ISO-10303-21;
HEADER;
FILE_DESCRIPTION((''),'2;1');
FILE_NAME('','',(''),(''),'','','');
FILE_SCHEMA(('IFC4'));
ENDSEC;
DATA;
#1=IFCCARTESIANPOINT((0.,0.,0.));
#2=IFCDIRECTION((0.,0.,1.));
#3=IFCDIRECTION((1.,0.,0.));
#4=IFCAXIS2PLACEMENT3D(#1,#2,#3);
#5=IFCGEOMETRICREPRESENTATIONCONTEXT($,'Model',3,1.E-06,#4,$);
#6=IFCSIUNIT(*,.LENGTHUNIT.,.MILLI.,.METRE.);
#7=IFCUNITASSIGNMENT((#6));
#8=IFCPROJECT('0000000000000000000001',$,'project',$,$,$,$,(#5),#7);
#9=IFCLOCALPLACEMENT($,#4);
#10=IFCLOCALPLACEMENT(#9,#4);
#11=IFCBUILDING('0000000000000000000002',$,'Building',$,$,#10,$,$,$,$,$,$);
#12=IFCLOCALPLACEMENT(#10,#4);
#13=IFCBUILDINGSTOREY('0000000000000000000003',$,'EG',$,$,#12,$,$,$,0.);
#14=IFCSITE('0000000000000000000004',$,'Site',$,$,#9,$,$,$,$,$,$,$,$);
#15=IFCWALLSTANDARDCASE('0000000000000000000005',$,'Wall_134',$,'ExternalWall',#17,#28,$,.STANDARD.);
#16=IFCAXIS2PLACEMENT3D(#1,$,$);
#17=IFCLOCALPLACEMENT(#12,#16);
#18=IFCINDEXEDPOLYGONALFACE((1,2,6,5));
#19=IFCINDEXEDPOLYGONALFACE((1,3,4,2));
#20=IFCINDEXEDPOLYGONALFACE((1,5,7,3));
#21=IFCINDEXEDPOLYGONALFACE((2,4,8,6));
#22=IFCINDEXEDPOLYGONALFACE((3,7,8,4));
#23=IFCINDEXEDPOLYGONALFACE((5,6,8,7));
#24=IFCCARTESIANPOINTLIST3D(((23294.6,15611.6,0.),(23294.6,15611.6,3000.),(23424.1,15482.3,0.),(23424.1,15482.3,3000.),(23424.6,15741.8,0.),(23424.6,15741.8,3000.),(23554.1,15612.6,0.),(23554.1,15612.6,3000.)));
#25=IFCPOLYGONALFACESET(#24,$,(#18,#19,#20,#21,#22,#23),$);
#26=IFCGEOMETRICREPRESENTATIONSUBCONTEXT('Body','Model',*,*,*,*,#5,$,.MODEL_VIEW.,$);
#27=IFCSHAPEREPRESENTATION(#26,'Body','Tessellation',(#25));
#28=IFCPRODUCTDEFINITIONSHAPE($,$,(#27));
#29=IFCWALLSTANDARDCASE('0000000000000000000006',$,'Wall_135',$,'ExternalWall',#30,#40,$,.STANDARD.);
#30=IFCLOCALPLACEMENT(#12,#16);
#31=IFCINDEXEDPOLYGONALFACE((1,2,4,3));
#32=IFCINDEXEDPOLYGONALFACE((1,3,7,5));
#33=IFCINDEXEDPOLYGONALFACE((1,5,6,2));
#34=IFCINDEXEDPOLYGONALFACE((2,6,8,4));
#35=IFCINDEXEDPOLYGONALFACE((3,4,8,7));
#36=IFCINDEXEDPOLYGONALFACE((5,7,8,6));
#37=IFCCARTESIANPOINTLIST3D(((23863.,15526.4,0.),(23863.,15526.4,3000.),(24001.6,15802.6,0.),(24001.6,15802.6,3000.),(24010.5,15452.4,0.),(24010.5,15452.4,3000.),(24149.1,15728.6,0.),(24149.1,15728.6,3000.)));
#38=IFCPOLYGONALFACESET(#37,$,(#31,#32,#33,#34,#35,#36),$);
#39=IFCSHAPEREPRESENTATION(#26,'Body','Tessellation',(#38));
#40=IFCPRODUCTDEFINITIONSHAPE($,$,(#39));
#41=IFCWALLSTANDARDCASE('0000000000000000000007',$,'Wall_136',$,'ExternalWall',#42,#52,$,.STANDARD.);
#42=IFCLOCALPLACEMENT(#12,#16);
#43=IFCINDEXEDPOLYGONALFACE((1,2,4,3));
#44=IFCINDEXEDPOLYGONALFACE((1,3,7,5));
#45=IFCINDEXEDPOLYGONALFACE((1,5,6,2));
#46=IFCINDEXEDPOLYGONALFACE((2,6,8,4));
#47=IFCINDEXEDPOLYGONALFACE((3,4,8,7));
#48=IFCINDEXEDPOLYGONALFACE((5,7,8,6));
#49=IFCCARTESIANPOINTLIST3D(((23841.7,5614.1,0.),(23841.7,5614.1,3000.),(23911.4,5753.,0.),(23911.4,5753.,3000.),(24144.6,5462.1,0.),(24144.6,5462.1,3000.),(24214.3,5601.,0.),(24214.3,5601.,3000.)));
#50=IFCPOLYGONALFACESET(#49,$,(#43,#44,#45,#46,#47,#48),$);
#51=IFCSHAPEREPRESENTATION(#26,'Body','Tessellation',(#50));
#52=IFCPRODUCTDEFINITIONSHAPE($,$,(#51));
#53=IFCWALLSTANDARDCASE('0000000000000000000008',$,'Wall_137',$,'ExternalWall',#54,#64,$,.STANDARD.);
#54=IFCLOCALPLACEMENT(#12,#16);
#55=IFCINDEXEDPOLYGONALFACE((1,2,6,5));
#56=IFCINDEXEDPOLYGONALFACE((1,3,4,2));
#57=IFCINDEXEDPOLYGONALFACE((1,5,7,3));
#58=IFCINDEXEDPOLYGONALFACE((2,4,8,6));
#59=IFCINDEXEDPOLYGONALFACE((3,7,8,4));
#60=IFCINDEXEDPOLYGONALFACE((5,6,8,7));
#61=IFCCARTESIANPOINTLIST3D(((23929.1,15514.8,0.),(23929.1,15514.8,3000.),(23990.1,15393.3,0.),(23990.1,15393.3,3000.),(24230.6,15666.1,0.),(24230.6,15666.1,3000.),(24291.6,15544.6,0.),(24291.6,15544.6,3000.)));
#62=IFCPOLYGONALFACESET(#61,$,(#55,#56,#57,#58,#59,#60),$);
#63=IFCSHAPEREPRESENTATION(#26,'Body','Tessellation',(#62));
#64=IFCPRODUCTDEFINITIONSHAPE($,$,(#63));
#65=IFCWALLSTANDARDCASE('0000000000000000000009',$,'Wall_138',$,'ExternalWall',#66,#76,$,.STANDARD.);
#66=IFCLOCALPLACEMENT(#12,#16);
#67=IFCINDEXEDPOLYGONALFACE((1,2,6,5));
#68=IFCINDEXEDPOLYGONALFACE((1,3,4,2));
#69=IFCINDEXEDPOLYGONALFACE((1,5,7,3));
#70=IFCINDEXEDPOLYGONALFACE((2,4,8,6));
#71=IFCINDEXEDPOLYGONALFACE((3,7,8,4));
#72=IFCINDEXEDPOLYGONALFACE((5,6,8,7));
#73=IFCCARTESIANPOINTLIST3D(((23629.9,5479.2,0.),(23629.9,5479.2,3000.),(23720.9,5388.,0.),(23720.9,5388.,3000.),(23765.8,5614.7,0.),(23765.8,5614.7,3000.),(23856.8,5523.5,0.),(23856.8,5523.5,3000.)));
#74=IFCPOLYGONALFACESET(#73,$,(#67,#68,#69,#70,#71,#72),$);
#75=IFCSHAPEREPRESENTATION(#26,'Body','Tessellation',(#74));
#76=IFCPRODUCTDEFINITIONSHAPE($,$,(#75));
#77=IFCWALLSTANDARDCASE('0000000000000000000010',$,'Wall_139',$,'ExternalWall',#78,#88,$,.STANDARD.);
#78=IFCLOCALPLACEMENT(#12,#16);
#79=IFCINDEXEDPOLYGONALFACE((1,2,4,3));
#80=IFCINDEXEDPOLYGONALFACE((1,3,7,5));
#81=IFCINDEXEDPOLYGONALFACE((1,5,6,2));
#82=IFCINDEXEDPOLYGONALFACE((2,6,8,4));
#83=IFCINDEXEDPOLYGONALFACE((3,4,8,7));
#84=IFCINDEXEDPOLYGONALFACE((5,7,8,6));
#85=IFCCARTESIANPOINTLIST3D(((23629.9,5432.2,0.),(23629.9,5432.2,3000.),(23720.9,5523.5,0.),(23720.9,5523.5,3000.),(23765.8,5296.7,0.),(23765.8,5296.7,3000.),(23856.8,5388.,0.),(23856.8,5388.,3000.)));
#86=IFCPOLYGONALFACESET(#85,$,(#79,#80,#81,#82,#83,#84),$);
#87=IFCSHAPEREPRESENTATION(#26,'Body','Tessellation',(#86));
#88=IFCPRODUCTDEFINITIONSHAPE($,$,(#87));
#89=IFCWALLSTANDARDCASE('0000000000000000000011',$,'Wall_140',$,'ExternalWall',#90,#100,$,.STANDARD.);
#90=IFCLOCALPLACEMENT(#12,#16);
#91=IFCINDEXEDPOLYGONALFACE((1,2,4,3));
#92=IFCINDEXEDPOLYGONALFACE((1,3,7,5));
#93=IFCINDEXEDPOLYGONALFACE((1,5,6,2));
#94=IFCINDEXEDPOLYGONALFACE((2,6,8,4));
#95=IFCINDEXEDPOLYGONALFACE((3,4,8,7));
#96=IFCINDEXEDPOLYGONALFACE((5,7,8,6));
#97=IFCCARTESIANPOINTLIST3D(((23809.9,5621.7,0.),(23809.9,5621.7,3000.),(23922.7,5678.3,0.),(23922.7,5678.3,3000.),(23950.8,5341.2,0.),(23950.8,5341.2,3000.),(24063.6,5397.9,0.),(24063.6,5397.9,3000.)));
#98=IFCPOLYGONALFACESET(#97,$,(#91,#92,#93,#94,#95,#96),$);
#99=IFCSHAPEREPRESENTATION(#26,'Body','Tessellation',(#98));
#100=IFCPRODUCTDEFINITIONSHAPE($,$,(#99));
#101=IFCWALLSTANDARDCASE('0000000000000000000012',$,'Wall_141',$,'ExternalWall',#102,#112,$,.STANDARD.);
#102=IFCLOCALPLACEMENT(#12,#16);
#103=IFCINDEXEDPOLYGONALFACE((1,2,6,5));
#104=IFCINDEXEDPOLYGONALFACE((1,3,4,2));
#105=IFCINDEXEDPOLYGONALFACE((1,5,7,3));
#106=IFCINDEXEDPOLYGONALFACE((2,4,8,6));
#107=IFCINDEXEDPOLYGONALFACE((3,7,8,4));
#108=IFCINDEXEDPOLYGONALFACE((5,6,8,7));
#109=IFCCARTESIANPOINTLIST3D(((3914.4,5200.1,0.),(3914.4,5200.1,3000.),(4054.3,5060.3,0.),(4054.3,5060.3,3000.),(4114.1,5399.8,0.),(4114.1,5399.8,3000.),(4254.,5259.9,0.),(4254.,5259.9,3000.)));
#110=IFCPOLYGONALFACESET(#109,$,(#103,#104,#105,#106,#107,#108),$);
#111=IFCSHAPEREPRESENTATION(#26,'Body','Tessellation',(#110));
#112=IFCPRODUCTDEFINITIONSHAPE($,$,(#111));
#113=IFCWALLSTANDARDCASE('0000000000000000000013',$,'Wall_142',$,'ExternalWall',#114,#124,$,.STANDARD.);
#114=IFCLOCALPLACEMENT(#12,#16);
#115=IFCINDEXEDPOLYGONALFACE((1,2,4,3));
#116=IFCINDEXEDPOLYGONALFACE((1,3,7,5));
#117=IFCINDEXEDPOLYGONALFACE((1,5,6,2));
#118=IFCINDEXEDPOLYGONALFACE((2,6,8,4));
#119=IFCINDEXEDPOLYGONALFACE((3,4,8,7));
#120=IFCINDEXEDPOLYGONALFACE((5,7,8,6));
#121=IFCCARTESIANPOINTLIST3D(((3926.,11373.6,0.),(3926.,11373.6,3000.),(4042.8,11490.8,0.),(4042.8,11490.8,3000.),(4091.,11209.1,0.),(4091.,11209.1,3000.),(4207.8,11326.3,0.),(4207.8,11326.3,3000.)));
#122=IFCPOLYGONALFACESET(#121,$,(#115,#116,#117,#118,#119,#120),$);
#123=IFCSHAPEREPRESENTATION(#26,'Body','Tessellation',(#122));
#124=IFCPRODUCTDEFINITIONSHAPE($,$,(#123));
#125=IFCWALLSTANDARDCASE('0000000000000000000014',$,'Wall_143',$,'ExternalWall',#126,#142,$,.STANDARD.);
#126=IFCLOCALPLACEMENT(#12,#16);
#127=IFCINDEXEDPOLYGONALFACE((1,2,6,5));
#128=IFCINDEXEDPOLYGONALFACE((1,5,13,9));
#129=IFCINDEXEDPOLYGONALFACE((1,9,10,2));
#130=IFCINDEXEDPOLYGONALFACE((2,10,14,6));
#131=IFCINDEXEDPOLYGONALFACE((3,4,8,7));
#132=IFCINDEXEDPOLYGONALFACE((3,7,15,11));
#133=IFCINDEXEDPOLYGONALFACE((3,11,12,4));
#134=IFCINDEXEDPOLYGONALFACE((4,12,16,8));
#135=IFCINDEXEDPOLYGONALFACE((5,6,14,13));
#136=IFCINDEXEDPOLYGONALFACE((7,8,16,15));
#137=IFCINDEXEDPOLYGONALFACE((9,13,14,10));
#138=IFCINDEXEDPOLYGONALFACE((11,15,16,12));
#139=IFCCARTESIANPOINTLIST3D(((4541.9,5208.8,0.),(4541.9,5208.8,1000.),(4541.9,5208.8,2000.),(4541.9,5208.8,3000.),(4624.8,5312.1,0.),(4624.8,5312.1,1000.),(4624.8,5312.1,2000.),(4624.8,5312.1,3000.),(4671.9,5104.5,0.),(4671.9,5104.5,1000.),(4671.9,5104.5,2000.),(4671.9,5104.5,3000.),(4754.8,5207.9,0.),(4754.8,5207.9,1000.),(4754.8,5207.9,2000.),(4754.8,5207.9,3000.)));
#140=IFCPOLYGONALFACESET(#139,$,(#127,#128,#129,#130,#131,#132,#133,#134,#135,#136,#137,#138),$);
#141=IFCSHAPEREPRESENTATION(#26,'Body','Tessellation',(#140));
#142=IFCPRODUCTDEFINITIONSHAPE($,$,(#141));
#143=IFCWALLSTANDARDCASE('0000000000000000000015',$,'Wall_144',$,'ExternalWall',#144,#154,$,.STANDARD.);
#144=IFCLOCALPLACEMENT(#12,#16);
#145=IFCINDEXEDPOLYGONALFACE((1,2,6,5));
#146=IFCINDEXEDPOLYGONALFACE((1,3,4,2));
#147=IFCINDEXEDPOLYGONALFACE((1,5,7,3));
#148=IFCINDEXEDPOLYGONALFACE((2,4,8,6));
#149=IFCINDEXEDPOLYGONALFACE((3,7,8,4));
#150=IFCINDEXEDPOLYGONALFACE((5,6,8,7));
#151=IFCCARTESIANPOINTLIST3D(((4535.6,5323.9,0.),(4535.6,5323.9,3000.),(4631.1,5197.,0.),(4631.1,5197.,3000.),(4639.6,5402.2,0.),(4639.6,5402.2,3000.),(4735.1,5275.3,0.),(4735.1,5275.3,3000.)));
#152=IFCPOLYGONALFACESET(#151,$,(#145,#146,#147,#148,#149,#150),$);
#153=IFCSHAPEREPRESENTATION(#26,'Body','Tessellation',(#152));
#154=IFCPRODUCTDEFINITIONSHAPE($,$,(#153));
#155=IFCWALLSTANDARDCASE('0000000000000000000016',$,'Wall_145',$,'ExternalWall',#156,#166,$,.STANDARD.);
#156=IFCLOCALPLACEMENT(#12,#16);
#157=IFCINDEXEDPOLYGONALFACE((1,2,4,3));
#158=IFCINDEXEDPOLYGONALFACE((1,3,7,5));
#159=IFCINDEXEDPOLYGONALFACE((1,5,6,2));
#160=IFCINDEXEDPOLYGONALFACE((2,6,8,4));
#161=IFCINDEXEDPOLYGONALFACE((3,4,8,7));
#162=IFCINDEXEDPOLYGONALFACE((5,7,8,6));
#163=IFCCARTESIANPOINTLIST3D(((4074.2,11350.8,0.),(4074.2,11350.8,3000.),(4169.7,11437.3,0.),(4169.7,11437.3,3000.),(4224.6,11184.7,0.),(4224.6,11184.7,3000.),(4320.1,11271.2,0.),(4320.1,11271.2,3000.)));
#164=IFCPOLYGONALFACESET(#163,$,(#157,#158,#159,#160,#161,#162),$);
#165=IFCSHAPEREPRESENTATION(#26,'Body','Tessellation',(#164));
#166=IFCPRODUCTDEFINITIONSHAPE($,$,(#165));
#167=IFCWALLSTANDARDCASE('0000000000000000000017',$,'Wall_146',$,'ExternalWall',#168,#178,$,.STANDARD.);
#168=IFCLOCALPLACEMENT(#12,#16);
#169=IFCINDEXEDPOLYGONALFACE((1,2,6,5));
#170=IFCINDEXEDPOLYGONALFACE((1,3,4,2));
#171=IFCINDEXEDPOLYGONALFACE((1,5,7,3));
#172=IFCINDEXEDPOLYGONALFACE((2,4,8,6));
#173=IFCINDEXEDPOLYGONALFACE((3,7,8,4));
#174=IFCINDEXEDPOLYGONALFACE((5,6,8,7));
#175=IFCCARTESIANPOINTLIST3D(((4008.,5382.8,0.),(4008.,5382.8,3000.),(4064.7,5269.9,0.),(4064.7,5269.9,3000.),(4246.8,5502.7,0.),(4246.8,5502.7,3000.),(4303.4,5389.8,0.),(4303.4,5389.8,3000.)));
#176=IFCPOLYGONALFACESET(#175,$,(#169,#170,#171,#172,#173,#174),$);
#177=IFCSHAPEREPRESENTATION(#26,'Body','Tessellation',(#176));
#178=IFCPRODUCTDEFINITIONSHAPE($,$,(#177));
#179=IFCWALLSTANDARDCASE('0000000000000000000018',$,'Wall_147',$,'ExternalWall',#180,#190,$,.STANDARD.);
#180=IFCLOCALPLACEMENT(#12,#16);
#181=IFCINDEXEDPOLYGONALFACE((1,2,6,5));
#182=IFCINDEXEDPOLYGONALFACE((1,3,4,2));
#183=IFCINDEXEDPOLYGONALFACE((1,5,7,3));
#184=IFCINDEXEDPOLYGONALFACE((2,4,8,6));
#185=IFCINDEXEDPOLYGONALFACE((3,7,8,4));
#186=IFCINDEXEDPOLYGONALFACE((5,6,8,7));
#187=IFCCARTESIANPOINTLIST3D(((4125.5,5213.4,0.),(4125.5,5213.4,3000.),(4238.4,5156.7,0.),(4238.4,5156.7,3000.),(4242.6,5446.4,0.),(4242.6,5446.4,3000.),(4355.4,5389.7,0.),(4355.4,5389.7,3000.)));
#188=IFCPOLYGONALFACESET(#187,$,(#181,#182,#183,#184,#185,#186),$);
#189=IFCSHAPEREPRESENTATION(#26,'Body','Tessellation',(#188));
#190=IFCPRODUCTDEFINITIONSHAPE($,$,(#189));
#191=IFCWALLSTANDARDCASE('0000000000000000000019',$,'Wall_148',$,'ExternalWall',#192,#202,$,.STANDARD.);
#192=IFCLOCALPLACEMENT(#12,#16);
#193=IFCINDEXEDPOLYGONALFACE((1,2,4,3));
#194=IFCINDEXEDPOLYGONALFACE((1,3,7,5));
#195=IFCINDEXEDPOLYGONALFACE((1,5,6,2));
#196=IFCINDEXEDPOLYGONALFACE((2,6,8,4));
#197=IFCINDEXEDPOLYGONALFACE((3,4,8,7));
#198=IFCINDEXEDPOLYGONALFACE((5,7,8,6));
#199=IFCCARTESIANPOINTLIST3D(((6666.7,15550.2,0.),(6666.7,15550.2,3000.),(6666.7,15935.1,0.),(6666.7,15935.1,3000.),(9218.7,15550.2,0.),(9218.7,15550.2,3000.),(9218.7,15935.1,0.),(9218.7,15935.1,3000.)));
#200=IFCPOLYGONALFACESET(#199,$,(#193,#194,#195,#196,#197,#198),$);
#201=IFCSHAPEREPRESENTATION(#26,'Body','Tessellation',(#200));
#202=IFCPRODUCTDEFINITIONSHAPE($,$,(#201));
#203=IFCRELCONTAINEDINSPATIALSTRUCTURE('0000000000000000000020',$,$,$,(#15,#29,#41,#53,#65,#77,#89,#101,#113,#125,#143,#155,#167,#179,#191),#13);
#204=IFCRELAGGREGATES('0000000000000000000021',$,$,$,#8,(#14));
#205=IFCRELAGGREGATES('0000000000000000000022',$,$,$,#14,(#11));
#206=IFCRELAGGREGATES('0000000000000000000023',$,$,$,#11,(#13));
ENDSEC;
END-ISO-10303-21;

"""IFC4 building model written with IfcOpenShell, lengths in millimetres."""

from ifc_helpers import new_model, si_unit, frame, origin_with_axes, place, context, subcontext, project, spatial, rectangle, extrude, element, save


model = new_model("IFC4")

# Units and contexts
model_context = context("Model", 3, precision=1e-06, world=origin_with_axes())
body_context = subcontext(model_context, "Body", "Model", "MODEL_VIEW")
ifc_project = project(units=[si_unit("LENGTHUNIT", "METRE", prefix="MILLI")], contexts=[model_context])

# Site, building, storey
site_placement = place(None, origin_with_axes())
site = spatial("IfcSite", under=ifc_project, at=site_placement, Name="Site")
building_placement = place(site_placement, origin_with_axes())
building = spatial("IfcBuilding", under=site, at=building_placement, Name="Building")
storey_placement = place(building_placement, origin_with_axes())
storey = spatial("IfcBuildingStorey", under=building, at=storey_placement, Name="EG", Elevation=0.0)

# Walls
wall_1_placement = place(storey_placement, origin_with_axes())
element("IfcWallStandardCase", 1, at=wall_1_placement, inside=storey, Name="Wall_134", ObjectType="ExternalWall", PredefinedType="STANDARD", context=body_context, shape_type="SweptSolid", body=[
    extrude(rectangle(XDim=184.0, YDim=183.0), frame((23424.3, 15612.1, 0.0), z_axis=(0.0, 0.0, 1.0), x_axis=(-0.706427, -0.707786, 0.0)), (0.0, 0.0, 1.0), 3000.0),
])
wall_2_placement = place(storey_placement, origin_with_axes())
element("IfcWallStandardCase", 2, at=wall_2_placement, inside=storey, Name="Wall_135", ObjectType="ExternalWall", PredefinedType="STANDARD", context=body_context, shape_type="SweptSolid", body=[
    extrude(rectangle(XDim=165.0, YDim=309.0), frame((24006.1, 15627.5, 0.0), z_axis=(0.0, 0.0, 1.0), x_axis=(-0.89382, 0.448425, 0.0)), (0.0, 0.0, 1.0), 3000.0),
])
wall_3_placement = place(storey_placement, origin_with_axes())
element("IfcWallStandardCase", 3, at=wall_3_placement, inside=storey, Name="Wall_136", ObjectType="ExternalWall", PredefinedType="STANDARD", context=body_context, shape_type="SweptSolid", body=[
    extrude(rectangle(XDim=155.3, YDim=338.9), frame((24028.0, 5607.5, 0.0), z_axis=(0.0, 0.0, 1.0), x_axis=(-0.448501, -0.893782, 0.0)), (0.0, 0.0, 1.0), 3000.0),
])
wall_4_placement = place(storey_placement, origin_with_axes())
element("IfcWallStandardCase", 4, at=wall_4_placement, inside=storey, Name="Wall_137", ObjectType="ExternalWall", PredefinedType="STANDARD", context=body_context, shape_type="SweptSolid", body=[
    extrude(rectangle(XDim=136.0, YDim=337.3), frame((24110.3, 15529.7, 0.0), z_axis=(0.0, 0.0, 1.0), x_axis=(-0.448684, 0.89369, 0.0)), (0.0, 0.0, 1.0), 3000.0),
])
wall_5_placement = place(storey_placement, origin_with_axes())
element("IfcWallStandardCase", 5, at=wall_5_placement, inside=storey, Name="Wall_138", ObjectType="ExternalWall", PredefinedType="STANDARD", context=body_context, shape_type="SweptSolid", body=[
    extrude(rectangle(XDim=128.9, YDim=191.9), frame((23743.3, 5501.3, 0.0), z_axis=(0.0, 0.0, 1.0), x_axis=(0.706136, -0.708076, 0.0)), (0.0, 0.0, 1.0), 3000.0),
])
wall_6_placement = place(storey_placement, origin_with_axes())
element("IfcWallStandardCase", 6, at=wall_6_placement, inside=storey, Name="Wall_139", ObjectType="ExternalWall", PredefinedType="STANDARD", context=body_context, shape_type="SweptSolid", body=[
    extrude(rectangle(XDim=128.9, YDim=191.9), frame((23743.3, 5410.1, 0.0), z_axis=(0.0, 0.0, 1.0), x_axis=(-0.706136, -0.708076, 0.0)), (0.0, 0.0, 1.0), 3000.0),
])
wall_7_placement = place(storey_placement, origin_with_axes())
element("IfcWallStandardCase", 7, at=wall_7_placement, inside=storey, Name="Wall_140", ObjectType="ExternalWall", PredefinedType="STANDARD", context=body_context, shape_type="SweptSolid", body=[
    extrude(rectangle(XDim=126.3, YDim=313.8), frame((23936.8, 5509.8, 0.0), z_axis=(0.0, 0.0, 1.0), x_axis=(-0.893634, -0.448797, 0.0)), (0.0, 0.0, 1.0), 3000.0),
])
wall_8_placement = place(storey_placement, origin_with_axes())
element("IfcWallStandardCase", 8, at=wall_8_placement, inside=storey, Name="Wall_141", ObjectType="ExternalWall", PredefinedType="STANDARD", context=body_context, shape_type="SweptSolid", body=[
    extrude(rectangle(XDim=282.4, YDim=197.8), frame((4084.2, 5230.0, 0.0), z_axis=(0.0, 0.0, 1.0), x_axis=(-0.707107, -0.707107, 0.0)), (0.0, 0.0, 1.0), 3000.0),
])
wall_9_placement = place(storey_placement, origin_with_axes())
element("IfcWallStandardCase", 9, at=wall_9_placement, inside=storey, Name="Wall_142", ObjectType="ExternalWall", PredefinedType="STANDARD", context=body_context, shape_type="SweptSolid", body=[
    extrude(rectangle(XDim=233.0, YDim=165.5), frame((4066.9, 11350.0, 0.0), z_axis=(0.0, 0.0, 1.0), x_axis=(-0.708179, 0.706033, 0.0)), (0.0, 0.0, 1.0), 3000.0),
])

# Wall, opening
wall_10_placement = place(storey_placement, origin_with_axes())
wall_10 = element("IfcWallStandardCase", 10, at=wall_10_placement, inside=storey, Name="Wall_143", ObjectType="ExternalWall", PredefinedType="STANDARD", context=body_context, shape_type="SweptSolid", body=[
    extrude(rectangle(XDim=166.6, YDim=132.5), frame((4648.4, 5208.3, 0.0), z_axis=(0.0, 0.0, 1.0), x_axis=(0.780136, -0.625609, 0.0)), (0.0, 0.0, 1.0), 3000.0),
])
opening_1_placement = place(wall_10_placement, origin_with_axes())
element("IfcOpeningElement", 11, at=opening_1_placement, inside=storey, cuts=wall_10, context=body_context, shape_type="SweptSolid", body=[
    extrude(rectangle(XDim=600.0, YDim=132.5), frame((4664.1, 5195.7, 1000.0), z_axis=(0.0, 0.0, 1.0), x_axis=(0.780136, -0.625609, 0.0)), (0.0, 0.0, 1.0), 1000.0),
])

# Walls
wall_11_placement = place(storey_placement, origin_with_axes())
element("IfcWallStandardCase", 12, at=wall_11_placement, inside=storey, Name="Wall_144", ObjectType="ExternalWall", PredefinedType="STANDARD", context=body_context, shape_type="SweptSolid", body=[
    extrude(rectangle(XDim=130.2, YDim=158.8), frame((4635.4, 5299.6, 0.0), z_axis=(0.0, 0.0, 1.0), x_axis=(0.799077, 0.601229, 0.0)), (0.0, 0.0, 1.0), 3000.0),
])
wall_12_placement = place(storey_placement, origin_with_axes())
element("IfcWallStandardCase", 13, at=wall_12_placement, inside=storey, Name="Wall_145", ObjectType="ExternalWall", PredefinedType="STANDARD", context=body_context, shape_type="SweptSolid", body=[
    extrude(rectangle(XDim=128.9, YDim=224.1), frame((4197.1, 11311.0, 0.0), z_axis=(0.0, 0.0, 1.0), x_axis=(0.741168, 0.67132, 0.0)), (0.0, 0.0, 1.0), 3000.0),
])
wall_13_placement = place(storey_placement, origin_with_axes())
element("IfcWallStandardCase", 14, at=wall_13_placement, inside=storey, Name="Wall_146", ObjectType="ExternalWall", PredefinedType="STANDARD", context=body_context, shape_type="SweptSolid", body=[
    extrude(rectangle(XDim=126.3, YDim=267.2), frame((4155.7, 5386.3, 0.0), z_axis=(0.0, 0.0, 1.0), x_axis=(0.448797, -0.893634, 0.0)), (0.0, 0.0, 1.0), 3000.0),
])
wall_14_placement = place(storey_placement, origin_with_axes())
element("IfcWallStandardCase", 15, at=wall_14_placement, inside=storey, Name="Wall_147", ObjectType="ExternalWall", PredefinedType="STANDARD", context=body_context, shape_type="SweptSolid", body=[
    extrude(rectangle(XDim=126.3, YDim=260.7), frame((4240.5, 5301.5, 0.0), z_axis=(0.0, 0.0, 1.0), x_axis=(0.893634, -0.448797, 0.0)), (0.0, 0.0, 1.0), 3000.0),
])
wall_15_placement = place(storey_placement, origin_with_axes())
element("IfcWallStandardCase", 16, at=wall_15_placement, inside=storey, Name="Wall_148", ObjectType="ExternalWall", PredefinedType="STANDARD", context=body_context, shape_type="SweptSolid", body=[
    extrude(rectangle(XDim=2552.0, YDim=384.9), frame((7942.7, 15742.7, 0.0), z_axis=(0.0, 0.0, 1.0), x_axis=(1.0, 0.0, 0.0)), (0.0, 0.0, 1.0), 3000.0),
])

save(model, "model.ifc")
